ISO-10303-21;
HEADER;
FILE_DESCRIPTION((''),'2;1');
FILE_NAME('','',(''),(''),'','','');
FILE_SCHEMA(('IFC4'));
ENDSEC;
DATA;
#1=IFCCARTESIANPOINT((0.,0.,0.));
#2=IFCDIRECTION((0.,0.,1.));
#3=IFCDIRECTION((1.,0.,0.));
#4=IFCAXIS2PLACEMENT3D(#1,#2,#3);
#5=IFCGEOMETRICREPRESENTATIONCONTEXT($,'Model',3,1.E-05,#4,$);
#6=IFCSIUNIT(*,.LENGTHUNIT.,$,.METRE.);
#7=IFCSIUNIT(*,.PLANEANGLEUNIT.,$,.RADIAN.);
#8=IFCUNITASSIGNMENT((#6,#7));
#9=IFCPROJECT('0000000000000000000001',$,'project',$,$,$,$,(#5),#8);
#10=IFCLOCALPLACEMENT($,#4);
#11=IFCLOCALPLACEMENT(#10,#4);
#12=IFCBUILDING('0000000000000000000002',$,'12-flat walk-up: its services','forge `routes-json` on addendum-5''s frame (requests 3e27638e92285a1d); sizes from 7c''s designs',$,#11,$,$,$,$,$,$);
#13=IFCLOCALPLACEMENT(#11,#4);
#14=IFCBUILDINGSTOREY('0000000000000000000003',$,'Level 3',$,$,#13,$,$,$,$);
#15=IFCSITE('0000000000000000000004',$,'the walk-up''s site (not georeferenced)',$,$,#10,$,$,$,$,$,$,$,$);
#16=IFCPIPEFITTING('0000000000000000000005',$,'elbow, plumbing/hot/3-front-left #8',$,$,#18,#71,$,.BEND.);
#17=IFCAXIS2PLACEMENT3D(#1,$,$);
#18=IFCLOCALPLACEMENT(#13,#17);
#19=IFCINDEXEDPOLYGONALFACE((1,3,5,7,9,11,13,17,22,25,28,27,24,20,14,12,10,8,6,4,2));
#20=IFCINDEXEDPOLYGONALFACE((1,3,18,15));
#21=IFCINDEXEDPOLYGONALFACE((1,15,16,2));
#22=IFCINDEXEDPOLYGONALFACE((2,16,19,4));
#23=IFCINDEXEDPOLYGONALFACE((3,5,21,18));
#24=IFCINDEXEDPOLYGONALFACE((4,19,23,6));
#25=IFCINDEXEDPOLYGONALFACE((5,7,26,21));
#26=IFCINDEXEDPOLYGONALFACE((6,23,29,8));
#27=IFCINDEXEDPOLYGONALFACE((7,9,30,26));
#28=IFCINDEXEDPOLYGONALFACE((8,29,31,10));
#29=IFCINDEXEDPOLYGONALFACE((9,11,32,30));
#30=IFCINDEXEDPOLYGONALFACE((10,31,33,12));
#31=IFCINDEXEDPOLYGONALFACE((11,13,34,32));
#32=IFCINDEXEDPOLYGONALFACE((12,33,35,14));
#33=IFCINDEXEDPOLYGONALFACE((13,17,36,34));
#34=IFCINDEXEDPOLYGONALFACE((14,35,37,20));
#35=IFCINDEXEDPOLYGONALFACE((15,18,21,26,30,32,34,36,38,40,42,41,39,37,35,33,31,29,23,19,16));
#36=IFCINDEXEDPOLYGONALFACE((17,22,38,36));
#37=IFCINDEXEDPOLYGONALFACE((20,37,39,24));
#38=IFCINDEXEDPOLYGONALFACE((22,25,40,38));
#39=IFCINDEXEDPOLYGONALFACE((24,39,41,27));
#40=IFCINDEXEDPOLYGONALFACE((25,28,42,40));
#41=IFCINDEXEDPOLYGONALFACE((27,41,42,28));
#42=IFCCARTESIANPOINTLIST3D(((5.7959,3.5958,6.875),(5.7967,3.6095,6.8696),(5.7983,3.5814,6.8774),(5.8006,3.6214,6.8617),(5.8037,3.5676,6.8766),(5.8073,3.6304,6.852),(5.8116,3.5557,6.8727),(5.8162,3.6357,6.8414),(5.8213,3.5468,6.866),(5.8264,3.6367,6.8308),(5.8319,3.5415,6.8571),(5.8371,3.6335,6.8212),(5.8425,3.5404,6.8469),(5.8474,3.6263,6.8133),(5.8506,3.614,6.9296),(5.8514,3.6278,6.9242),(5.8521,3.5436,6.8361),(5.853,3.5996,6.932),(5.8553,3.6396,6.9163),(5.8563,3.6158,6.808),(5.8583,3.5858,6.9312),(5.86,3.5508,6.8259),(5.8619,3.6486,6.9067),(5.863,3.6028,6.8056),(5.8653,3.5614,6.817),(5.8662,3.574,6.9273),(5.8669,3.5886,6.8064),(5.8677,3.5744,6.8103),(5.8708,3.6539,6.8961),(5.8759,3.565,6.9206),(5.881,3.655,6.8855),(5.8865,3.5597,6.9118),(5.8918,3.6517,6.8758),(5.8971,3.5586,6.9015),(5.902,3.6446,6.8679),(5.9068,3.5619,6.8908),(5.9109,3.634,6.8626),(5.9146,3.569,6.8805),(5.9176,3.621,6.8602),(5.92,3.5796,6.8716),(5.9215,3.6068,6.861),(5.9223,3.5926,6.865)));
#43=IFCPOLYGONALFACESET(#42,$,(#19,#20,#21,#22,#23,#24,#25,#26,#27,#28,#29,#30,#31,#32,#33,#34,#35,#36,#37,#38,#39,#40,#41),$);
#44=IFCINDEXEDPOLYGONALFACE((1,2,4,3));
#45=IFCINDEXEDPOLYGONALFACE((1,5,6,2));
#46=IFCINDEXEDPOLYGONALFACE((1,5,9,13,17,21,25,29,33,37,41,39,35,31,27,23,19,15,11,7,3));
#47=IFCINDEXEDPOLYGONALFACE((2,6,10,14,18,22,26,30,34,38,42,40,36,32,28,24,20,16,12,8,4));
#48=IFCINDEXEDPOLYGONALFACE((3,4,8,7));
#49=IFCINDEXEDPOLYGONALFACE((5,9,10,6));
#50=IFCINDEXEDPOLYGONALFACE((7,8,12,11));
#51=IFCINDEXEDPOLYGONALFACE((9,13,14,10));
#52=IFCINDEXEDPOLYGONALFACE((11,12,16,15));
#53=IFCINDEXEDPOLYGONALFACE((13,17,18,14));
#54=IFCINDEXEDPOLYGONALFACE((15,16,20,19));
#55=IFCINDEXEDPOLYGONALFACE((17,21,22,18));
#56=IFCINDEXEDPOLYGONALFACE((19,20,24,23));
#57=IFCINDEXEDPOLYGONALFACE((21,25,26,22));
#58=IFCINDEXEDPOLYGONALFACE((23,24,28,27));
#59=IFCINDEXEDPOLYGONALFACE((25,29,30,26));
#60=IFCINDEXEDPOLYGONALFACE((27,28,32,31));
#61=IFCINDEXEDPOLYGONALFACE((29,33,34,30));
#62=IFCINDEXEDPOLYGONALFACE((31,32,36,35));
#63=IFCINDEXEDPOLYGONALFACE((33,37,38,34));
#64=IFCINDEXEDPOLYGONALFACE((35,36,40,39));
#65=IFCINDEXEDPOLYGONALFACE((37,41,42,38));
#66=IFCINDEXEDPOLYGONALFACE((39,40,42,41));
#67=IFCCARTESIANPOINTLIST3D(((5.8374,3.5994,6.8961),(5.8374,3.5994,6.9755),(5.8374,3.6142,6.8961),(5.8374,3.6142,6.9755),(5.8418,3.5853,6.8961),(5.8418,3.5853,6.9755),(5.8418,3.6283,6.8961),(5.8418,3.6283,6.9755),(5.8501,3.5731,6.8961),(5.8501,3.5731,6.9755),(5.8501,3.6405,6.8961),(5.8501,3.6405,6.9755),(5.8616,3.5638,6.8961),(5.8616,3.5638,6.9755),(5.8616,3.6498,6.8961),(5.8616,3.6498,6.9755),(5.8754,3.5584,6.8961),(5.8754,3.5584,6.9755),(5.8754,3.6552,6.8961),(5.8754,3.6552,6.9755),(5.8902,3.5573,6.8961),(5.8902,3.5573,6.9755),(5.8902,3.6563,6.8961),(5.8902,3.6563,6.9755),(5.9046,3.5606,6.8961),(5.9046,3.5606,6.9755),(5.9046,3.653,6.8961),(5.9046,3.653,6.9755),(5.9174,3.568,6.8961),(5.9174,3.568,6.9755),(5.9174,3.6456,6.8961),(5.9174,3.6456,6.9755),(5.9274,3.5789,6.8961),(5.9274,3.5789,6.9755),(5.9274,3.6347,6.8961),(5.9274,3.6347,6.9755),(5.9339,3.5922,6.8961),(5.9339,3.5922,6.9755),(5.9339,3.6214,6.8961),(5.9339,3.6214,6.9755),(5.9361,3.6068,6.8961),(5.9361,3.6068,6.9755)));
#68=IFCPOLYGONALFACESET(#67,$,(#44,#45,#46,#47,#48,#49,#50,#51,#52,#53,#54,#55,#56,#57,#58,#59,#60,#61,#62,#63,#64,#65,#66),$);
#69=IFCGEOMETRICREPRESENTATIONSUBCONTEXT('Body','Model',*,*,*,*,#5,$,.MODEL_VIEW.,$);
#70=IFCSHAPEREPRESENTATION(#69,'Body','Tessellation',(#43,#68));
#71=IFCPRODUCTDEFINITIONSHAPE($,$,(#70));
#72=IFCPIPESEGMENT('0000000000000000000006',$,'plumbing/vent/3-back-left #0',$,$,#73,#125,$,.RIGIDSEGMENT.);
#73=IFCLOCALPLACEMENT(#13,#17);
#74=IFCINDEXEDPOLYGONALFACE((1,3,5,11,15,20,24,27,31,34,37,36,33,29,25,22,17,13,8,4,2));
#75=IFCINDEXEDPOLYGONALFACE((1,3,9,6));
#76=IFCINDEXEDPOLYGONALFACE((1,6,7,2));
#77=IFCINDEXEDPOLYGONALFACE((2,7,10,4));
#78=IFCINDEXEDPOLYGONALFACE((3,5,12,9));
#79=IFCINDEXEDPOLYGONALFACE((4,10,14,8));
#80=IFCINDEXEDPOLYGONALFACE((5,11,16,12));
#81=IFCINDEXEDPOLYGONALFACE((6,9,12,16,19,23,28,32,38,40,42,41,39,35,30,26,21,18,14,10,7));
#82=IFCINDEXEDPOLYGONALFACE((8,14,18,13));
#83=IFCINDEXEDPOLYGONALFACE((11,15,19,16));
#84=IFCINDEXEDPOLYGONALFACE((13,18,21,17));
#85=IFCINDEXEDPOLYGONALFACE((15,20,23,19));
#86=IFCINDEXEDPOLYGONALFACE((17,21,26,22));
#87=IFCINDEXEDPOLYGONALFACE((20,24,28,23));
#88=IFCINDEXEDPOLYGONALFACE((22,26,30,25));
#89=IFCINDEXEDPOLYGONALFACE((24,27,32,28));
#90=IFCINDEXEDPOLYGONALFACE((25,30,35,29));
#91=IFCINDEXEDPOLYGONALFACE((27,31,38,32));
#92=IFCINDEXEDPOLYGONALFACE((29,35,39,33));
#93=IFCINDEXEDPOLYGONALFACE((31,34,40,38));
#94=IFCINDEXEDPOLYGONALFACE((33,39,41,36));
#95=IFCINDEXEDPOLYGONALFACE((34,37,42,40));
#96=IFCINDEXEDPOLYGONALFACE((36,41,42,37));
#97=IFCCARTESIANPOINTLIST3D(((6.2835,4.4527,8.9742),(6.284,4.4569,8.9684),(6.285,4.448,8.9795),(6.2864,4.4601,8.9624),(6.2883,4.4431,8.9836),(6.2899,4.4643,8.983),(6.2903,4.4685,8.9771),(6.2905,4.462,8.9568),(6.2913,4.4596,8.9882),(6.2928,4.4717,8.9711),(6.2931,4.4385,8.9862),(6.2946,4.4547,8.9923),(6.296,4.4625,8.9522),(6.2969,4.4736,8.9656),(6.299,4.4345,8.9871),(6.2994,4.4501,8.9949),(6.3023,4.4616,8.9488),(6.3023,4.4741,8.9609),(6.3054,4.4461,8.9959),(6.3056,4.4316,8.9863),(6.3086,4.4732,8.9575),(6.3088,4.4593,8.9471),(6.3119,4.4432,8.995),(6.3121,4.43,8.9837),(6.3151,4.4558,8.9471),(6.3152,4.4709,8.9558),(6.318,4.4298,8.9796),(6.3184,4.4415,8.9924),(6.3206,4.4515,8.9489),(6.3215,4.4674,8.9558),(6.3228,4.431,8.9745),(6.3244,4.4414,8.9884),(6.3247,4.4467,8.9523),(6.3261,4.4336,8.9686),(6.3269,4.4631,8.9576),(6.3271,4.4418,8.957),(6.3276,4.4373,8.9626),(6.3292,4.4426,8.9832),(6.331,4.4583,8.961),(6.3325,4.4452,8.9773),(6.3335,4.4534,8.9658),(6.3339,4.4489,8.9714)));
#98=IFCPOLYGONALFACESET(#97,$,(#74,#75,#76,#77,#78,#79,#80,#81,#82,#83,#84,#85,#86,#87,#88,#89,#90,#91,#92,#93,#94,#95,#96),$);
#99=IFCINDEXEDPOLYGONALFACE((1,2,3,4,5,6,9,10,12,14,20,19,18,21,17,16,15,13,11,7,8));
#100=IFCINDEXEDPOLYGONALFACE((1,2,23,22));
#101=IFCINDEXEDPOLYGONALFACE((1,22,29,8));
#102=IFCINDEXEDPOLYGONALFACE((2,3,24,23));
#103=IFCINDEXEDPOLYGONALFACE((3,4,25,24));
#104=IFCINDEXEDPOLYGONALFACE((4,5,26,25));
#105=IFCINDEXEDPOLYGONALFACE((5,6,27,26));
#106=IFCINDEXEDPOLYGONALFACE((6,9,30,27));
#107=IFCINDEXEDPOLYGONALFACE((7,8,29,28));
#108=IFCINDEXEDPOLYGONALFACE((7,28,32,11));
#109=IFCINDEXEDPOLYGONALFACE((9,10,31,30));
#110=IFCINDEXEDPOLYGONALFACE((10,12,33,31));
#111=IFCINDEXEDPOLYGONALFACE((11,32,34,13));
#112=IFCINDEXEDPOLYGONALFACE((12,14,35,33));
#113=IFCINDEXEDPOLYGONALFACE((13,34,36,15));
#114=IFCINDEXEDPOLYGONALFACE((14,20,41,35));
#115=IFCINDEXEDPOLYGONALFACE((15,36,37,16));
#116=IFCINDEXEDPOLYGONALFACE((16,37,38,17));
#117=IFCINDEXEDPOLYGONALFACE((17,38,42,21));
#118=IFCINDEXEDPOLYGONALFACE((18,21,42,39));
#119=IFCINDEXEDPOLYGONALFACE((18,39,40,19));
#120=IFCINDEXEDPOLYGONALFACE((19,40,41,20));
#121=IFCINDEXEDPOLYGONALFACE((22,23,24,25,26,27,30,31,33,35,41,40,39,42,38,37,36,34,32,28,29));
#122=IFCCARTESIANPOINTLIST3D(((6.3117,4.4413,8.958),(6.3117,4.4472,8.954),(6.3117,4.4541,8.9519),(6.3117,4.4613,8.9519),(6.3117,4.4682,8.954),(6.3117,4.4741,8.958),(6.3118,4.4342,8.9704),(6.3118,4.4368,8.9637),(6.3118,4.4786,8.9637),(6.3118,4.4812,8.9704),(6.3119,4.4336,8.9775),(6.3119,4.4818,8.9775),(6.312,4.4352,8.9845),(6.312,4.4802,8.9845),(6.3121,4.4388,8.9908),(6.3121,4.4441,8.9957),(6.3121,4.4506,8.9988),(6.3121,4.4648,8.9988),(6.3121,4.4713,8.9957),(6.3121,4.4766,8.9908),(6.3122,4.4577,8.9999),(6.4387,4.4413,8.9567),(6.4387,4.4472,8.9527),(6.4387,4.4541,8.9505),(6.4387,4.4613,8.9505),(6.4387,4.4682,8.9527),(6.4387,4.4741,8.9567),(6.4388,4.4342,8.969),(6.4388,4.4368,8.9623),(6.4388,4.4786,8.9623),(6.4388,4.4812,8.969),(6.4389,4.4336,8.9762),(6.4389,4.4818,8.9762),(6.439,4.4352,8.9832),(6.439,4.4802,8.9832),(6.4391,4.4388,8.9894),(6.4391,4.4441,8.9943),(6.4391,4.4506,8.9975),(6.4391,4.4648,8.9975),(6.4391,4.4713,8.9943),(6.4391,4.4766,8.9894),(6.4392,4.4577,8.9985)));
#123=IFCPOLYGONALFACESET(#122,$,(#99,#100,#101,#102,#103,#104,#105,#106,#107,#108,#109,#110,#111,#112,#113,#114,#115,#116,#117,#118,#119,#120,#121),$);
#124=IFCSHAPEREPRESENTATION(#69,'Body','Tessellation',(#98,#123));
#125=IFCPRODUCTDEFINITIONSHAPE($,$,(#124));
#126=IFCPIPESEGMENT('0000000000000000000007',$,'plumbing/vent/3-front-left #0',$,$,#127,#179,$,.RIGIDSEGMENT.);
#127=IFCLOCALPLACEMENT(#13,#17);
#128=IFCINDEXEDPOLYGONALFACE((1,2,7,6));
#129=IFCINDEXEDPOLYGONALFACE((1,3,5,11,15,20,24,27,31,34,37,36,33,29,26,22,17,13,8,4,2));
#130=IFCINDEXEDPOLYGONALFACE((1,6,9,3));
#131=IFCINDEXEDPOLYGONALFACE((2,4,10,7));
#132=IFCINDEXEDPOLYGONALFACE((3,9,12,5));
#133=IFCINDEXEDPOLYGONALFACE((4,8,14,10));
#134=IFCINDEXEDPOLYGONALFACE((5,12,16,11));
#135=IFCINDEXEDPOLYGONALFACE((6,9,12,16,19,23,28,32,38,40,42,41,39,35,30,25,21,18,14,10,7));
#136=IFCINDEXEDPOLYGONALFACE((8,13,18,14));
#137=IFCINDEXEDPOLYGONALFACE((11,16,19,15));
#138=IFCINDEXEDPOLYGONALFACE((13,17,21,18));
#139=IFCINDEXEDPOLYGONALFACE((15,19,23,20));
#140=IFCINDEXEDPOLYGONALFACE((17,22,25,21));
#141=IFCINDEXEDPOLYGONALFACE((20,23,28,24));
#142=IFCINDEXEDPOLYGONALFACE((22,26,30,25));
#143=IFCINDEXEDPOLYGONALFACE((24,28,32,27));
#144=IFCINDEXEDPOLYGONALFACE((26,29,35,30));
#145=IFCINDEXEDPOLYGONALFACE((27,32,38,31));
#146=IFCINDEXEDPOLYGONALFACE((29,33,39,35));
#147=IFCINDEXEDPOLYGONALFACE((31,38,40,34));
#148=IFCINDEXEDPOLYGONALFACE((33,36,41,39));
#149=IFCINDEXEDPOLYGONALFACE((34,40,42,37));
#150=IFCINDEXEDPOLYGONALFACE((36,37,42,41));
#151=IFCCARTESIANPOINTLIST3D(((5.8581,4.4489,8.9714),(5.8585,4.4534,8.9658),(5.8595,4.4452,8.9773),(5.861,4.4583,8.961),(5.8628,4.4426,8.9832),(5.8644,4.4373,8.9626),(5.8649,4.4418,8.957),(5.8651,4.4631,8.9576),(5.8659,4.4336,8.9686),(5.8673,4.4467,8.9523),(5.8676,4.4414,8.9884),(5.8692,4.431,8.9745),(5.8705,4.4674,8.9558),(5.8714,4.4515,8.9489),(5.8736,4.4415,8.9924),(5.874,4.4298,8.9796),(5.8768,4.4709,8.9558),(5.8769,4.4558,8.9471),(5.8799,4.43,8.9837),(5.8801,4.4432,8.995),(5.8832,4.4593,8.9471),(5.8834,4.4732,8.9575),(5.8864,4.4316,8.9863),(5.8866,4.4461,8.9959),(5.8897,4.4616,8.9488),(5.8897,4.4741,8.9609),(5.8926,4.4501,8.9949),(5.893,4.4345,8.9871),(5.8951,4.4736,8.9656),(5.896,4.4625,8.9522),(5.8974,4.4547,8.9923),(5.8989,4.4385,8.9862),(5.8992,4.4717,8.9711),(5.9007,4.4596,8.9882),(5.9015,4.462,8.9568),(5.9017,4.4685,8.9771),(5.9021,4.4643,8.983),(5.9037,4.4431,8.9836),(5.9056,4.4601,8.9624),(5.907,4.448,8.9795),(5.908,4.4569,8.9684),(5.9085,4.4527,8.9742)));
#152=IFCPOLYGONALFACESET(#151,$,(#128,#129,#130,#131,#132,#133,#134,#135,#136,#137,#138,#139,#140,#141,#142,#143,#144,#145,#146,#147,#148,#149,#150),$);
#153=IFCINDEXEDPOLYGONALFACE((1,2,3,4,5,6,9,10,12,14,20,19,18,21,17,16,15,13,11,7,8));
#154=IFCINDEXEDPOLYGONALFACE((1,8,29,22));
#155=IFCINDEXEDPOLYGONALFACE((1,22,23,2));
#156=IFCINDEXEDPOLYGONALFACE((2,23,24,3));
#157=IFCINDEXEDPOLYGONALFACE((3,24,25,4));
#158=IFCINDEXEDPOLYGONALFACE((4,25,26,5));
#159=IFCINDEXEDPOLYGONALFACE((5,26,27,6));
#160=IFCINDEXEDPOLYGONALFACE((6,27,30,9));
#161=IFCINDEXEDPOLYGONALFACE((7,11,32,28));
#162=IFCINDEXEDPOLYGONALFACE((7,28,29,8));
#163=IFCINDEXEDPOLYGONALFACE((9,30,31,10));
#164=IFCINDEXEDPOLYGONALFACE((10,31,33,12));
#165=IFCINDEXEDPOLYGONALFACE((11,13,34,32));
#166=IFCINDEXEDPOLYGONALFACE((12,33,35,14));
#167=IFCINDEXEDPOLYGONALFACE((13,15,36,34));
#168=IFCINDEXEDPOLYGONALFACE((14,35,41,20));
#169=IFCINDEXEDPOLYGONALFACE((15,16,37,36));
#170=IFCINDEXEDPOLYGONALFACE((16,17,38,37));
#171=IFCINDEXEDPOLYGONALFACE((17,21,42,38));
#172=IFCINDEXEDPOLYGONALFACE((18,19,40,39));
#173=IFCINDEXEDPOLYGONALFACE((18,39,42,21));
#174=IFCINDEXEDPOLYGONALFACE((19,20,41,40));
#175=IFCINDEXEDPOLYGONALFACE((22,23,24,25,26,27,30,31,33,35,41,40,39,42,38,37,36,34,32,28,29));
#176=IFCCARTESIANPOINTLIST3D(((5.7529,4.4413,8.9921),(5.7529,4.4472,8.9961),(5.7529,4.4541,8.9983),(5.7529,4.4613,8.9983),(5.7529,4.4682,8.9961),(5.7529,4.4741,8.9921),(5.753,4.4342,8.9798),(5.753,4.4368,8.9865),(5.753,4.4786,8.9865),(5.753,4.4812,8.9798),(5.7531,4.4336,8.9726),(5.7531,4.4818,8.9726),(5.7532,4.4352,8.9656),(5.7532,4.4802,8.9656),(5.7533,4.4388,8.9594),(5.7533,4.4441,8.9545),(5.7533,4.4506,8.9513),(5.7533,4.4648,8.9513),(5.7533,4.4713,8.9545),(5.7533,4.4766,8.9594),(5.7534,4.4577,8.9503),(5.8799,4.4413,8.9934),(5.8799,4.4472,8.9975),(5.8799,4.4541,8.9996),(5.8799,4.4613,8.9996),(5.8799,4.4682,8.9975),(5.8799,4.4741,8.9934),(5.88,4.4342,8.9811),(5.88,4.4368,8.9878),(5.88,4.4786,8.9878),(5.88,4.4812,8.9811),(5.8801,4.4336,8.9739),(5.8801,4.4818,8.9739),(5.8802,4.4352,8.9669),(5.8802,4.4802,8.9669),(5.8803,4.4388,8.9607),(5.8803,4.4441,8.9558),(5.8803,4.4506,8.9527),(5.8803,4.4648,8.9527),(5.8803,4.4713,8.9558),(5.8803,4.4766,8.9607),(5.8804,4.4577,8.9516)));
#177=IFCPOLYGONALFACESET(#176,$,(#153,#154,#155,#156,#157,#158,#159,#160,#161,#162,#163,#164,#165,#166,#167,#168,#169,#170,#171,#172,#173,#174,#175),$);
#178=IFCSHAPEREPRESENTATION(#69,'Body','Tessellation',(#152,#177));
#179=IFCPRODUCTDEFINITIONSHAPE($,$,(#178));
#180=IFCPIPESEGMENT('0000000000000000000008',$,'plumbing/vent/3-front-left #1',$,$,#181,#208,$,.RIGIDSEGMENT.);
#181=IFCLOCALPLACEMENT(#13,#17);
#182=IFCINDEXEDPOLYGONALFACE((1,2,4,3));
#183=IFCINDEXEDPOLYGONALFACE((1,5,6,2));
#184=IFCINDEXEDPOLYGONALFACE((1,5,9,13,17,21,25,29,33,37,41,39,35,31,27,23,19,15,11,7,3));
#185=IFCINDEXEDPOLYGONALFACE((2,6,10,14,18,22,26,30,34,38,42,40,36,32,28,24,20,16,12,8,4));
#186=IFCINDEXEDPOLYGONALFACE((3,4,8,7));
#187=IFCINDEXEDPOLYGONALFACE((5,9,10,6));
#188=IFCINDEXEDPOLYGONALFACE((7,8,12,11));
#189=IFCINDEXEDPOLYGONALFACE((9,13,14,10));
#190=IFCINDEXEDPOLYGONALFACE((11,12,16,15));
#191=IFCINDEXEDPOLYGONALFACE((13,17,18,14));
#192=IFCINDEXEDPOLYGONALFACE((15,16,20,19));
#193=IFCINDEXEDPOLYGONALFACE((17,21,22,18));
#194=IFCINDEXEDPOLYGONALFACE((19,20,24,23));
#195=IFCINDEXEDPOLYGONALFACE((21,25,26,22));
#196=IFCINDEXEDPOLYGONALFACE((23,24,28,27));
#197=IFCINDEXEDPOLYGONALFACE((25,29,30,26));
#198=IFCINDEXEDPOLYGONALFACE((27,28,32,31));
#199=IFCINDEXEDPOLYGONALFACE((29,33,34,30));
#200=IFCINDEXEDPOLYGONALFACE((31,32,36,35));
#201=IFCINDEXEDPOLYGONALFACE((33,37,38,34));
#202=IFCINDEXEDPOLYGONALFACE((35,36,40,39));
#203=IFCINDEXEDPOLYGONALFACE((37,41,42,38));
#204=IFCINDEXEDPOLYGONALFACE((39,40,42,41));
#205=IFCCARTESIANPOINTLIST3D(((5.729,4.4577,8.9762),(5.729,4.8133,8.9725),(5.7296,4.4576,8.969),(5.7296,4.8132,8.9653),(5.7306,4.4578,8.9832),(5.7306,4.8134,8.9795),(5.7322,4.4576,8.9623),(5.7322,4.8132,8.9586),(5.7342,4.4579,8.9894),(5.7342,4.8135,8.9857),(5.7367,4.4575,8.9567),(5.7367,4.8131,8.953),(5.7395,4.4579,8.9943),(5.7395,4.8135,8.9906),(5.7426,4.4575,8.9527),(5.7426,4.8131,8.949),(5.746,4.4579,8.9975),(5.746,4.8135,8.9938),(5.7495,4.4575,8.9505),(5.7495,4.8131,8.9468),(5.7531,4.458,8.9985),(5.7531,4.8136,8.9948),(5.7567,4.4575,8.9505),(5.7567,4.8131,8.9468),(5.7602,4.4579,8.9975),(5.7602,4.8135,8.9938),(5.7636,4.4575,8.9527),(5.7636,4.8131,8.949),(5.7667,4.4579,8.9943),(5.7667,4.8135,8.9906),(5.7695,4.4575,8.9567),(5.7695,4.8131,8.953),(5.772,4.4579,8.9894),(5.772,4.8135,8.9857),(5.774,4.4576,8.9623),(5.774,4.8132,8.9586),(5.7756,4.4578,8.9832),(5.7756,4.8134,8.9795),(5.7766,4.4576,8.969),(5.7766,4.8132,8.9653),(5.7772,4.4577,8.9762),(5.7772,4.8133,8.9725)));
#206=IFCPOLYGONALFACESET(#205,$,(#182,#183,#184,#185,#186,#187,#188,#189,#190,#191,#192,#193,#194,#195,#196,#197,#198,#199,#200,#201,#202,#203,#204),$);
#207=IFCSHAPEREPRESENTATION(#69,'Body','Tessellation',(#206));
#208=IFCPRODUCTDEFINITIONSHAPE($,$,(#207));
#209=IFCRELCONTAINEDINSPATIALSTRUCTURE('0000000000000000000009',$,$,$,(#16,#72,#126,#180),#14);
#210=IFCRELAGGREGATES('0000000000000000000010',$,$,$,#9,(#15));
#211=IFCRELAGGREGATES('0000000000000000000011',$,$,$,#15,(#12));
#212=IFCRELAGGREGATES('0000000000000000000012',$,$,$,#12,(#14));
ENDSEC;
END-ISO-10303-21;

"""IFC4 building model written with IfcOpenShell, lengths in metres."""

from ifc_helpers import new_model, entity, si_unit, frame, origin_with_axes, place, context, subcontext, project, spatial, element, save


model = new_model("IFC4")

# Units and contexts
model_context = context("Model", 3, precision=1e-05, world=origin_with_axes())
body_context = subcontext(model_context, "Body", "Model", "MODEL_VIEW")
ifc_project = project(units=[si_unit("LENGTHUNIT", "METRE"), si_unit("PLANEANGLEUNIT", "RADIAN")], contexts=[model_context])

# Site, building, storey
site_placement = place(None, origin_with_axes())
site = spatial("IfcSite", under=ifc_project, at=site_placement, Name="the walk-up's site (not georeferenced)")
building_placement = place(site_placement, origin_with_axes())
building = spatial("IfcBuilding", under=site, at=building_placement, Name="12-flat walk-up: its services", Description="forge `routes-json` on addendum-5's frame (requests 3e27638e92285a1d); sizes from 7c's designs")
storey_placement = place(building_placement, origin_with_axes())
storey = spatial("IfcBuildingStorey", under=building, at=storey_placement, Name="Level 3")

# Pipe fitting
pipe_fitting_1_placement = place(storey_placement, frame((5.8318, 3.5886, 6.8415), z_axis=(0.0, 0.0, 1.0), x_axis=(1.0, 0.0, 0.0)))
element("IfcPipeFitting", 1, at=pipe_fitting_1_placement, inside=storey, Name="elbow, plumbing/hot/3-front-left #8", PredefinedType="BEND", context=body_context, shape_type="AdvancedSweptSolid", body=[
    entity("IfcSweptDiskSolid", entity("IfcPolyline", [entity("IfcCartesianPoint", [0.0, 0.0, 0.0]), entity("IfcCartesianPoint", [0.0546, 0.0182, 0.0546])]), 0.0496),
    entity("IfcSweptDiskSolid", entity("IfcPolyline", [entity("IfcCartesianPoint", [0.0546, 0.0182, 0.0546]), entity("IfcCartesianPoint", [0.0546, 0.0182, 0.134])]), 0.0496),
])

# Pipe segments
pipe_segment_1_placement = place(storey_placement, frame((6.3056, 4.4461, 8.967), z_axis=(0.0, 0.0, 1.0), x_axis=(1.0, 0.0, 0.0)))
element("IfcPipeSegment", 2, at=pipe_segment_1_placement, inside=storey, Name="plumbing/vent/3-back-left #0", PredefinedType="RIGIDSEGMENT", context=body_context, shape_type="AdvancedSweptSolid", body=[
    entity("IfcSweptDiskSolid", entity("IfcPolyline", [entity("IfcCartesianPoint", [0.0, 0.0, 0.0]), entity("IfcCartesianPoint", [0.0063, 0.0116, 0.0087])]), 0.0241),
    entity("IfcSweptDiskSolid", entity("IfcPolyline", [entity("IfcCartesianPoint", [0.0063, 0.0116, 0.0087]), entity("IfcCartesianPoint", [0.1334, 0.0116, 0.0074])]), 0.0241),
])
pipe_segment_2_placement = place(storey_placement, frame((5.8864, 4.4461, 8.967), z_axis=(0.0, 0.0, 1.0), x_axis=(1.0, 0.0, 0.0)))
element("IfcPipeSegment", 3, at=pipe_segment_2_placement, inside=storey, Name="plumbing/vent/3-front-left #0", PredefinedType="RIGIDSEGMENT", context=body_context, shape_type="AdvancedSweptSolid", body=[
    entity("IfcSweptDiskSolid", entity("IfcPolyline", [entity("IfcCartesianPoint", [0.0, 0.0, 0.0]), entity("IfcCartesianPoint", [-0.0064, 0.0116, 0.0087])]), 0.0241),
    entity("IfcSweptDiskSolid", entity("IfcPolyline", [entity("IfcCartesianPoint", [-0.0064, 0.0116, 0.0087]), entity("IfcCartesianPoint", [-0.1334, 0.0116, 0.0074])]), 0.0241),
])
pipe_segment_3_placement = place(storey_placement, frame((5.7531, 4.4577, 8.9744), z_axis=(0.0, 0.0, 1.0), x_axis=(1.0, 0.0, 0.0)))
element("IfcPipeSegment", 4, at=pipe_segment_3_placement, inside=storey, Name="plumbing/vent/3-front-left #1", PredefinedType="RIGIDSEGMENT", context=body_context, shape_type="AdvancedSweptSolid", body=[
    entity("IfcSweptDiskSolid", entity("IfcPolyline", [entity("IfcCartesianPoint", [0.0, 0.0, 0.0]), entity("IfcCartesianPoint", [0.0, 0.3556, -0.0037])]), 0.0241),
])

save(model, "model.ifc")
